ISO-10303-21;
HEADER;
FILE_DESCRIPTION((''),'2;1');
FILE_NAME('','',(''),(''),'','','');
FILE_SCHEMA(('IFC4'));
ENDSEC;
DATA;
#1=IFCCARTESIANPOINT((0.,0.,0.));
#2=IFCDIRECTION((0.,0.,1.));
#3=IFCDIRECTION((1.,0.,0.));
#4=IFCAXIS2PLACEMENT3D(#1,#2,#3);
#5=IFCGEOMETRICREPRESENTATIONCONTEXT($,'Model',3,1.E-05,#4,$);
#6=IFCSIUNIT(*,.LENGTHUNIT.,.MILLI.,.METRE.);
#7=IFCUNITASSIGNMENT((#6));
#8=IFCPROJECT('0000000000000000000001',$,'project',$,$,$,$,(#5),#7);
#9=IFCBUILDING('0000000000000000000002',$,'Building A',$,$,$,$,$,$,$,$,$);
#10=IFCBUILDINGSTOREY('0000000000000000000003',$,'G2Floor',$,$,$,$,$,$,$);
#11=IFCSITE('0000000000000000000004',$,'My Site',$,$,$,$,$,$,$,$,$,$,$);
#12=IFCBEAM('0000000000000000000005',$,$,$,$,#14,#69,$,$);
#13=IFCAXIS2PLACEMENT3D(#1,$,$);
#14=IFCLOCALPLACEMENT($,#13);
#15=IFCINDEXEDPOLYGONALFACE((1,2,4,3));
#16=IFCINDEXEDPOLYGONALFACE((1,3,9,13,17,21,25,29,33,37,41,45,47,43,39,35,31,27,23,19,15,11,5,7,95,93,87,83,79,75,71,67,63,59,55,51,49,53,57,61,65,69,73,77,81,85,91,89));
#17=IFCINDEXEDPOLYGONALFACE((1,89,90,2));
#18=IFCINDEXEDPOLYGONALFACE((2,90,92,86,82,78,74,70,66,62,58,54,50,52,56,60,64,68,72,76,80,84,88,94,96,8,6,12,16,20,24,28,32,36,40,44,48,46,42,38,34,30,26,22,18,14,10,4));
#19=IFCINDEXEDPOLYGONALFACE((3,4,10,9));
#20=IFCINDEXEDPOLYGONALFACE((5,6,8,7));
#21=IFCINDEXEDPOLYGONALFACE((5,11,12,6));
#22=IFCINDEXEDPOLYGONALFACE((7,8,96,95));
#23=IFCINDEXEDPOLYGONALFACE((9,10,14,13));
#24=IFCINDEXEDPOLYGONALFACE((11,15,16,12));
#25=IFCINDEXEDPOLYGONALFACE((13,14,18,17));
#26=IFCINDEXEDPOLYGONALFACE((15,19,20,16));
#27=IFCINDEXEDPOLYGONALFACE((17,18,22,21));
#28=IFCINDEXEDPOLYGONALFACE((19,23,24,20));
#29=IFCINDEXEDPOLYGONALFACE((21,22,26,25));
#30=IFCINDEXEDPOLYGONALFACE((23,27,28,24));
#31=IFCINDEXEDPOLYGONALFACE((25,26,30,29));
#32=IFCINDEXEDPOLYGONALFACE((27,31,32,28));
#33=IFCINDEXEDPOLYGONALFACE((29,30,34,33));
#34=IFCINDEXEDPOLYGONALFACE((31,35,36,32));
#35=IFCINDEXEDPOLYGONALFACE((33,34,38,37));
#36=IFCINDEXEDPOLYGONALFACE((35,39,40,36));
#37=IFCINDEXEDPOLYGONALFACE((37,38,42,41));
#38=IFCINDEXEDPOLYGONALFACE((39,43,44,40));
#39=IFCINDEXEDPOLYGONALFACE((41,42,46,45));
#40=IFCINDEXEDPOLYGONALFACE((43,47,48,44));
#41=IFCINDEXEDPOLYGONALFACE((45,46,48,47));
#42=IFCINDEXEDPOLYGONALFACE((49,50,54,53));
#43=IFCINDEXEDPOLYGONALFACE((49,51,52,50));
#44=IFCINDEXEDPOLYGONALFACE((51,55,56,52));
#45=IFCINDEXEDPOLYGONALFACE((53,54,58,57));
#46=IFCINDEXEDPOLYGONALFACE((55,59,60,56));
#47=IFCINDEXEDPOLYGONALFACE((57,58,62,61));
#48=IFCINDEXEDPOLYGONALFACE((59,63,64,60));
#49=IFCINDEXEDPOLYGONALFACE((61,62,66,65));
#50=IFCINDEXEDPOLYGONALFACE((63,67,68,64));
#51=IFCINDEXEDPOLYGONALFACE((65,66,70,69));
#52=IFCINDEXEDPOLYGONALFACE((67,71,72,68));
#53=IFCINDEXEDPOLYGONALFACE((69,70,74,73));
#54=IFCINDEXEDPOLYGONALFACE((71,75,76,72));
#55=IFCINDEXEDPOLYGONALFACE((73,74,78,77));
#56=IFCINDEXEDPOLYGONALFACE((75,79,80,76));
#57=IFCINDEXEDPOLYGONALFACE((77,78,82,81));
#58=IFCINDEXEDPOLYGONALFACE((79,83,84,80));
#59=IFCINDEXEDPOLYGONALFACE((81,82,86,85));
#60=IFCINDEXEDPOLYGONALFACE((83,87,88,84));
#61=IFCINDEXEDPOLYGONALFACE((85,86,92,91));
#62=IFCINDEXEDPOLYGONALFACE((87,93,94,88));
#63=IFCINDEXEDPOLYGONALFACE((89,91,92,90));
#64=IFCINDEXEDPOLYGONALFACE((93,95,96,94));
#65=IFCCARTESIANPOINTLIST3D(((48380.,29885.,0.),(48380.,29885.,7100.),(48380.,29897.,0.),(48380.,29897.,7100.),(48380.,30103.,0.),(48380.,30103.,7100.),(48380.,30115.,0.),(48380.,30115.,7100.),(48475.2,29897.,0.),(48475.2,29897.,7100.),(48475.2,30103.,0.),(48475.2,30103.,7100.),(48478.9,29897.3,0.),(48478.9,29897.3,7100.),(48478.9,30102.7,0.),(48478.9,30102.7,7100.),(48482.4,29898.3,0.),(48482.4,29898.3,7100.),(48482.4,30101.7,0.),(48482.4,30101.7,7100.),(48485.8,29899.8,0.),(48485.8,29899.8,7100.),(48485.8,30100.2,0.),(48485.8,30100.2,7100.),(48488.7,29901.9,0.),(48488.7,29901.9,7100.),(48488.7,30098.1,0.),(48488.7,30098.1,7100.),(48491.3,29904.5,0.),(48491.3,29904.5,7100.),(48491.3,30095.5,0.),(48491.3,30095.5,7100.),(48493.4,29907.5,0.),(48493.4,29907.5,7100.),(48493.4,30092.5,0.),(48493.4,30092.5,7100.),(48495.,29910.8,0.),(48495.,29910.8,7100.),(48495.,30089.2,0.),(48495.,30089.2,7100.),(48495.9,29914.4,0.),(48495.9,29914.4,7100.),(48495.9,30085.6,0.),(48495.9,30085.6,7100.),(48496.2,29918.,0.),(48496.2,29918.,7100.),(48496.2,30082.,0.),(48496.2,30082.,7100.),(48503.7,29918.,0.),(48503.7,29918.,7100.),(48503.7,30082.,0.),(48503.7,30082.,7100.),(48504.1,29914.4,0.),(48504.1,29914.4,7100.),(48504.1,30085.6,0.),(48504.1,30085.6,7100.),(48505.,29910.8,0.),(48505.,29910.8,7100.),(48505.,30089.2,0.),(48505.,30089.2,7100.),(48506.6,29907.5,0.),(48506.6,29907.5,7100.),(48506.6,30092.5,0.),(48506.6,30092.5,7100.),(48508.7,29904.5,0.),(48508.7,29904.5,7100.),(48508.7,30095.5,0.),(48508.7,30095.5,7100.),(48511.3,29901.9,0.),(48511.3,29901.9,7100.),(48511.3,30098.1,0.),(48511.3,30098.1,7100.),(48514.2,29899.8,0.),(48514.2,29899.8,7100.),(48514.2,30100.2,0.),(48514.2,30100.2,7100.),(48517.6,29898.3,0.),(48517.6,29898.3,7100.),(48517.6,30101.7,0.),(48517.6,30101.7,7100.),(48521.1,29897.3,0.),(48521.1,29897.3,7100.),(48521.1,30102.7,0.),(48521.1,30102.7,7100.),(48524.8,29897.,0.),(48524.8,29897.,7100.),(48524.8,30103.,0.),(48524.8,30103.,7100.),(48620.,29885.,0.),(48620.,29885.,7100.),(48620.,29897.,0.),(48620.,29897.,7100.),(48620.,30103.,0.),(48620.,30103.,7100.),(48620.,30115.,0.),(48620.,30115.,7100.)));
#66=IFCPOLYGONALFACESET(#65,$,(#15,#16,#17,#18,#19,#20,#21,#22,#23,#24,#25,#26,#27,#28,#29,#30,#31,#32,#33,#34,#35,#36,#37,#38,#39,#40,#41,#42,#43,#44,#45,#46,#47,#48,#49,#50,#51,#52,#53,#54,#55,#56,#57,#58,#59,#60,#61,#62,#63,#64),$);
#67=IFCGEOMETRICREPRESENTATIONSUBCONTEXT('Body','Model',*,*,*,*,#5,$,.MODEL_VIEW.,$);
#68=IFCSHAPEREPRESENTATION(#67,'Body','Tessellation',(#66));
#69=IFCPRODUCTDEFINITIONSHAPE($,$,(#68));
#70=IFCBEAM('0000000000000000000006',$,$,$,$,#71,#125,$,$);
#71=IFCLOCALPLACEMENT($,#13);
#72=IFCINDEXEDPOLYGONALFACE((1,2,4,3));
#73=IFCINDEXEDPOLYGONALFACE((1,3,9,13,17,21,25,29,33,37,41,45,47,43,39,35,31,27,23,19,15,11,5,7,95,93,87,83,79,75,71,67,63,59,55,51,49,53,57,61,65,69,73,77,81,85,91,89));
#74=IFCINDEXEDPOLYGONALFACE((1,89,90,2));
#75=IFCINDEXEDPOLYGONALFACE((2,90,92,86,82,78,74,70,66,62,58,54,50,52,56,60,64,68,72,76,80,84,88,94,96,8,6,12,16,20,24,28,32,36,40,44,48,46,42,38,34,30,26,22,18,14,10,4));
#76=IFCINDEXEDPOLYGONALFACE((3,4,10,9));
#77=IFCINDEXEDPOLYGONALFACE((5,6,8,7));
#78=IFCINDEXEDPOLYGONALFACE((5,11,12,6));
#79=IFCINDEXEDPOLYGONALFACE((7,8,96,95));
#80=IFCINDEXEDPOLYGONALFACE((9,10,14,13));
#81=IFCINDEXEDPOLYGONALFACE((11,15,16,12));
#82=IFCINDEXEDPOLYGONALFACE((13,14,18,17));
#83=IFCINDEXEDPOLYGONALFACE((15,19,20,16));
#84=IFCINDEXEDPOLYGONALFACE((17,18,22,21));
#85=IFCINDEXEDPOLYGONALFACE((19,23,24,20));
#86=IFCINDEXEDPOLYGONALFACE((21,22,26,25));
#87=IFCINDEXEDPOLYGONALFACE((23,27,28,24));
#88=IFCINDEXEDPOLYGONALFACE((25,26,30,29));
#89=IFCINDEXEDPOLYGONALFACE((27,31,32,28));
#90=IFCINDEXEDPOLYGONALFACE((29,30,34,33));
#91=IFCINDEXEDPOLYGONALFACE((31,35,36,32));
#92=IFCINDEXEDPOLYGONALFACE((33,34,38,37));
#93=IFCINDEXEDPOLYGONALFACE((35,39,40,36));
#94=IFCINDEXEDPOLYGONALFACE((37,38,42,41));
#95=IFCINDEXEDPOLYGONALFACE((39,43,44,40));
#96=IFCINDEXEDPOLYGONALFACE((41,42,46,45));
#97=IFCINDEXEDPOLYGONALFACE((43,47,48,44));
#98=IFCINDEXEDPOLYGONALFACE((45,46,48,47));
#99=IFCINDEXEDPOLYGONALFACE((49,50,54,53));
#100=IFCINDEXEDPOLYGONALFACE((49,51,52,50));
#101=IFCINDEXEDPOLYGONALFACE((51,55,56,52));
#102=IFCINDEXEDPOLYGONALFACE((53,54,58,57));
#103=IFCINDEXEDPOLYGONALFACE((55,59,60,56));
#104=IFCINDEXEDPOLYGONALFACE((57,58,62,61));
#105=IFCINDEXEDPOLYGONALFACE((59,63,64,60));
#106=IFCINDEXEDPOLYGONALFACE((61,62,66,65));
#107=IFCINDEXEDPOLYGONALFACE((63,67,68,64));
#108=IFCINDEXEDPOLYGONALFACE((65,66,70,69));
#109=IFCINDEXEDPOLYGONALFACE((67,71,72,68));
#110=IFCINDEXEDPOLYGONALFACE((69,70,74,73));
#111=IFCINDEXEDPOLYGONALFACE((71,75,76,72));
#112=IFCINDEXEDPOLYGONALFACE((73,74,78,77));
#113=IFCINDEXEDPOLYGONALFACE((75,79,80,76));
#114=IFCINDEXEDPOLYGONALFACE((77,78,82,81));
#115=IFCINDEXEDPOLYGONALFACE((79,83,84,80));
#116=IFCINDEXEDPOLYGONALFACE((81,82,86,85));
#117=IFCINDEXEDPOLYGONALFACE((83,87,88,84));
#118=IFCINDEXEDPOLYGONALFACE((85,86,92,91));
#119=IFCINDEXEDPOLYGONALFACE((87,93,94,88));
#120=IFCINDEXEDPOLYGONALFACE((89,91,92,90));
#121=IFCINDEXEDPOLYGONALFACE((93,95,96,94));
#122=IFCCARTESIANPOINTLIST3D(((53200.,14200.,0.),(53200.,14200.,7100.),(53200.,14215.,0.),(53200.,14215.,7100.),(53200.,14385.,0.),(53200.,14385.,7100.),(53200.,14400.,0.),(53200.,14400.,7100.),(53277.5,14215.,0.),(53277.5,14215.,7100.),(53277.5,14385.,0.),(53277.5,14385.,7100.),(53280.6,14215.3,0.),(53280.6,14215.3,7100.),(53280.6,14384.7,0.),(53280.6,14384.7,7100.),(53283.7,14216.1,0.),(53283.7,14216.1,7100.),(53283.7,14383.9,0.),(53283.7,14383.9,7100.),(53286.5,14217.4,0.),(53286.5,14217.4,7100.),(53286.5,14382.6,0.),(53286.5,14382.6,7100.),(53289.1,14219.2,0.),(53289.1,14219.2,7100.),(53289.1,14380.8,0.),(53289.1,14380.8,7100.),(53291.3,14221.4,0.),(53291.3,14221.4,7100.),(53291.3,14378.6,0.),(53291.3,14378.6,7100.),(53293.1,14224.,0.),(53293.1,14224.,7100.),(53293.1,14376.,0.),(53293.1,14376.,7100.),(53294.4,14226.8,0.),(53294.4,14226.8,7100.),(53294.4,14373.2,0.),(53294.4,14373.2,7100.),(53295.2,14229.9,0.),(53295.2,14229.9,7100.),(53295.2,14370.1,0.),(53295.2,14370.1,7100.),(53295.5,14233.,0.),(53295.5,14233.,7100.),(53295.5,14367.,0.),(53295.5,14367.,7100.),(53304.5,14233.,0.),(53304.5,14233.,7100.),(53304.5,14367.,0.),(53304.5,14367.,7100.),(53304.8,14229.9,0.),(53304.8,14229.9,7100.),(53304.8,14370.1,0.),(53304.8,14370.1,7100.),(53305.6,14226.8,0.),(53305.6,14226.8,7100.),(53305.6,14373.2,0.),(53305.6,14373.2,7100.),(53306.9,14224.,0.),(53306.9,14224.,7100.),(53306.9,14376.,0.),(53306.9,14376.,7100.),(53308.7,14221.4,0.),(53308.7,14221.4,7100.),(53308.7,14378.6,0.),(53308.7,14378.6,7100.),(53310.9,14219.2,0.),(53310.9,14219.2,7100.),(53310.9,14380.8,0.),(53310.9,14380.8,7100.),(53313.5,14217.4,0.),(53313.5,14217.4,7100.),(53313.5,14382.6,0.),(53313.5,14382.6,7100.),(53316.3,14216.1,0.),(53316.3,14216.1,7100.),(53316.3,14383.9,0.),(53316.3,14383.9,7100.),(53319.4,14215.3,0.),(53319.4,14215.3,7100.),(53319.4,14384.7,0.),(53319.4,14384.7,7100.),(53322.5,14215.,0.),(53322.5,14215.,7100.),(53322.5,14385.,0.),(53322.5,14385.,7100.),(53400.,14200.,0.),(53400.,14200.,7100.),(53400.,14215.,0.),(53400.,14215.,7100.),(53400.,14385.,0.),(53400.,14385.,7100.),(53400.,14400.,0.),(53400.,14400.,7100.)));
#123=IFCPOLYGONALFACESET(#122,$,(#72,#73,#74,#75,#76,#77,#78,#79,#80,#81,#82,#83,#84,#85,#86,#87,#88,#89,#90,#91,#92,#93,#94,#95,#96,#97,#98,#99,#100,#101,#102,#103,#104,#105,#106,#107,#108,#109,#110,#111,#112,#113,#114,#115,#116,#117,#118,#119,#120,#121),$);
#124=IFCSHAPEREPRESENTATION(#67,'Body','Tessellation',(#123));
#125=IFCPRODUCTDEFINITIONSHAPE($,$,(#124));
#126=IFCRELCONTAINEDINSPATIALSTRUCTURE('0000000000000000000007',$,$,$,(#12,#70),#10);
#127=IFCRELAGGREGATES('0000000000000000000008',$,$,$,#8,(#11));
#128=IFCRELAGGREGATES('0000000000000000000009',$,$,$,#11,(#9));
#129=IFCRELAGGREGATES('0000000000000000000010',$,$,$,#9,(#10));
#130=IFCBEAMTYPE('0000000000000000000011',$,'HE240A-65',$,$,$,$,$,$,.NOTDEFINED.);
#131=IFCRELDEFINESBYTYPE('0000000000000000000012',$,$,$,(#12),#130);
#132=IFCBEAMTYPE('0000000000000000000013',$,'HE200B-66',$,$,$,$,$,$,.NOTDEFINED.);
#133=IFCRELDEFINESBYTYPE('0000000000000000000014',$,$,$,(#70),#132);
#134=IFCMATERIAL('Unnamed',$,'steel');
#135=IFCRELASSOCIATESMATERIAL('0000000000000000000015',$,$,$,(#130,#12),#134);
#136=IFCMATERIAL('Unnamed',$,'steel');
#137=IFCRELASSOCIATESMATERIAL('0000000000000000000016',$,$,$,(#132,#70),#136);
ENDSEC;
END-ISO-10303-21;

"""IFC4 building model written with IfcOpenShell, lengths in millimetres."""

from ifc_helpers import new_model, si_unit, frame, origin_with_axes, place, context, subcontext, project, spatial, polyline, outline, extrude, material, material_profile, profile_set, profile_usage, type_object, element, save


model = new_model("IFC4")

# Units and contexts
model_context = context("Model", 3, precision=1e-05, world=origin_with_axes())
body_context = subcontext(model_context, "Body", "Model", "MODEL_VIEW")
ifc_project = project(units=[si_unit("LENGTHUNIT", "METRE", prefix="MILLI")], contexts=[model_context])

# Site, building, storey
site = spatial("IfcSite", under=ifc_project, Name="My Site")
building = spatial("IfcBuilding", under=site, Name="Building A")
storey = spatial("IfcBuildingStorey", under=building, Name="G2Floor")

# Beams
ifc_material_1 = material(Name="Unnamed", Category="steel")
ifc_material_profile_1 = material_profile(ifc_material_1, outline(polyline([(120.0, -115.0), (120.0, -103.0), (120.0, -103.0), (24.8, -103.0), (24.8, -103.0), (21.1, -102.7), (21.1, -102.7), (17.6, -101.7), (17.6, -101.7), (14.2, -100.2), (14.2, -100.2), (11.3, -98.1), (11.3, -98.1), (8.7, -95.5), (8.7, -95.5), (6.6, -92.5), (6.6, -92.5), (5.0, -89.2), (5.0, -89.2), (4.1, -85.6), (4.1, -85.6), (3.8, -82.0), (3.8, -82.0), (3.8, 82.0), (3.8, 82.0), (4.1, 85.6), (4.1, 85.6), (5.0, 89.2), (5.0, 89.2), (6.6, 92.5), (6.6, 92.5), (8.7, 95.5), (8.7, 95.5), (11.3, 98.1), (11.3, 98.1), (14.2, 100.2), (14.2, 100.2), (17.6, 101.7), (17.6, 101.7), (21.1, 102.7), (21.1, 102.7), (24.8, 103.0), (24.8, 103.0), (120.0, 103.0), (120.0, 103.0), (120.0, 115.0), (120.0, 115.0), (-120.0, 115.0), (-120.0, 115.0), (-120.0, 103.0), (-120.0, 103.0), (-24.8, 103.0), (-24.8, 103.0), (-21.1, 102.7), (-21.1, 102.7), (-17.6, 101.7), (-17.6, 101.7), (-14.2, 100.2), (-14.2, 100.2), (-11.3, 98.1), (-11.3, 98.1), (-8.7, 95.5), (-8.7, 95.5), (-6.6, 92.5), (-6.6, 92.5), (-5.0, 89.2), (-5.0, 89.2), (-4.1, 85.6), (-4.1, 85.6), (-3.8, 82.0), (-3.8, 82.0), (-3.8, -82.0), (-3.8, -82.0), (-4.1, -85.6), (-4.1, -85.6), (-5.0, -89.2), (-5.0, -89.2), (-6.6, -92.5), (-6.6, -92.5), (-8.7, -95.5), (-8.7, -95.5), (-11.3, -98.1), (-11.3, -98.1), (-14.2, -100.2), (-14.2, -100.2), (-17.6, -101.7), (-17.6, -101.7), (-21.1, -102.7), (-21.1, -102.7), (-24.8, -103.0), (-24.8, -103.0), (-120.0, -103.0), (-120.0, -103.0), (-120.0, -115.0), (-120.0, -115.0), (120.0, -115.0)])))
ifc_profile_set_1 = profile_set([ifc_material_profile_1], Name="HE240A-65")
ifc_profile_usage_1 = profile_usage(ifc_profile_set_1)
beam_type_1 = type_object("IfcBeamType", Name="HE240A-65", PredefinedType="NOTDEFINED", material=ifc_profile_set_1)
beam_1_placement = place(None, frame((48500.0, 30000.0, 0.0), z_axis=(0.0, 0.0, 1.0), x_axis=(1.0, 0.0, 0.0)))
element("IfcBeam", 1, at=beam_1_placement, inside=storey, type_object=beam_type_1, material=ifc_profile_usage_1, context=body_context, shape_type="SweptSolid", body=[
    extrude(outline(polyline([(120.0, -115.0), (120.0, -103.0), (120.0, -103.0), (24.8, -103.0), (24.8, -103.0), (21.1, -102.7), (21.1, -102.7), (17.6, -101.7), (17.6, -101.7), (14.2, -100.2), (14.2, -100.2), (11.3, -98.1), (11.3, -98.1), (8.7, -95.5), (8.7, -95.5), (6.6, -92.5), (6.6, -92.5), (5.0, -89.2), (5.0, -89.2), (4.1, -85.6), (4.1, -85.6), (3.8, -82.0), (3.8, -82.0), (3.8, 82.0), (3.8, 82.0), (4.1, 85.6), (4.1, 85.6), (5.0, 89.2), (5.0, 89.2), (6.6, 92.5), (6.6, 92.5), (8.7, 95.5), (8.7, 95.5), (11.3, 98.1), (11.3, 98.1), (14.2, 100.2), (14.2, 100.2), (17.6, 101.7), (17.6, 101.7), (21.1, 102.7), (21.1, 102.7), (24.8, 103.0), (24.8, 103.0), (120.0, 103.0), (120.0, 103.0), (120.0, 115.0), (120.0, 115.0), (-120.0, 115.0), (-120.0, 115.0), (-120.0, 103.0), (-120.0, 103.0), (-24.8, 103.0), (-24.8, 103.0), (-21.1, 102.7), (-21.1, 102.7), (-17.6, 101.7), (-17.6, 101.7), (-14.2, 100.2), (-14.2, 100.2), (-11.3, 98.1), (-11.3, 98.1), (-8.7, 95.5), (-8.7, 95.5), (-6.6, 92.5), (-6.6, 92.5), (-5.0, 89.2), (-5.0, 89.2), (-4.1, 85.6), (-4.1, 85.6), (-3.8, 82.0), (-3.8, 82.0), (-3.8, -82.0), (-3.8, -82.0), (-4.1, -85.6), (-4.1, -85.6), (-5.0, -89.2), (-5.0, -89.2), (-6.6, -92.5), (-6.6, -92.5), (-8.7, -95.5), (-8.7, -95.5), (-11.3, -98.1), (-11.3, -98.1), (-14.2, -100.2), (-14.2, -100.2), (-17.6, -101.7), (-17.6, -101.7), (-21.1, -102.7), (-21.1, -102.7), (-24.8, -103.0), (-24.8, -103.0), (-120.0, -103.0), (-120.0, -103.0), (-120.0, -115.0), (-120.0, -115.0), (120.0, -115.0)])), origin_with_axes(), (0.0, 0.0, 1.0), 7100.0),
])
ifc_material_2 = material(Name="Unnamed", Category="steel")
ifc_material_profile_2 = material_profile(ifc_material_2, outline(polyline([(100.0, -100.0), (100.0, -85.0), (100.0, -85.0), (22.5, -85.0), (22.5, -85.0), (19.4, -84.7), (19.4, -84.7), (16.3, -83.9), (16.3, -83.9), (13.5, -82.6), (13.5, -82.6), (10.9, -80.8), (10.9, -80.8), (8.7, -78.6), (8.7, -78.6), (6.9, -76.0), (6.9, -76.0), (5.6, -73.2), (5.6, -73.2), (4.8, -70.1), (4.8, -70.1), (4.5, -67.0), (4.5, -67.0), (4.5, 67.0), (4.5, 67.0), (4.8, 70.1), (4.8, 70.1), (5.6, 73.2), (5.6, 73.2), (6.9, 76.0), (6.9, 76.0), (8.7, 78.6), (8.7, 78.6), (10.9, 80.8), (10.9, 80.8), (13.5, 82.6), (13.5, 82.6), (16.3, 83.9), (16.3, 83.9), (19.4, 84.7), (19.4, 84.7), (22.5, 85.0), (22.5, 85.0), (100.0, 85.0), (100.0, 85.0), (100.0, 100.0), (100.0, 100.0), (-100.0, 100.0), (-100.0, 100.0), (-100.0, 85.0), (-100.0, 85.0), (-22.5, 85.0), (-22.5, 85.0), (-19.4, 84.7), (-19.4, 84.7), (-16.3, 83.9), (-16.3, 83.9), (-13.5, 82.6), (-13.5, 82.6), (-10.9, 80.8), (-10.9, 80.8), (-8.7, 78.6), (-8.7, 78.6), (-6.9, 76.0), (-6.9, 76.0), (-5.6, 73.2), (-5.6, 73.2), (-4.8, 70.1), (-4.8, 70.1), (-4.5, 67.0), (-4.5, 67.0), (-4.5, -67.0), (-4.5, -67.0), (-4.8, -70.1), (-4.8, -70.1), (-5.6, -73.2), (-5.6, -73.2), (-6.9, -76.0), (-6.9, -76.0), (-8.7, -78.6), (-8.7, -78.6), (-10.9, -80.8), (-10.9, -80.8), (-13.5, -82.6), (-13.5, -82.6), (-16.3, -83.9), (-16.3, -83.9), (-19.4, -84.7), (-19.4, -84.7), (-22.5, -85.0), (-22.5, -85.0), (-100.0, -85.0), (-100.0, -85.0), (-100.0, -100.0), (-100.0, -100.0), (100.0, -100.0)])))
ifc_profile_set_2 = profile_set([ifc_material_profile_2], Name="HE200B-66")
ifc_profile_usage_2 = profile_usage(ifc_profile_set_2)
beam_type_2 = type_object("IfcBeamType", Name="HE200B-66", PredefinedType="NOTDEFINED", material=ifc_profile_set_2)
beam_2_placement = place(None, frame((53300.0, 14300.0, 0.0), z_axis=(0.0, 0.0, 1.0), x_axis=(1.0, 0.0, 0.0)))
element("IfcBeam", 2, at=beam_2_placement, inside=storey, type_object=beam_type_2, material=ifc_profile_usage_2, context=body_context, shape_type="SweptSolid", body=[
    extrude(outline(polyline([(100.0, -100.0), (100.0, -85.0), (100.0, -85.0), (22.5, -85.0), (22.5, -85.0), (19.4, -84.7), (19.4, -84.7), (16.3, -83.9), (16.3, -83.9), (13.5, -82.6), (13.5, -82.6), (10.9, -80.8), (10.9, -80.8), (8.7, -78.6), (8.7, -78.6), (6.9, -76.0), (6.9, -76.0), (5.6, -73.2), (5.6, -73.2), (4.8, -70.1), (4.8, -70.1), (4.5, -67.0), (4.5, -67.0), (4.5, 67.0), (4.5, 67.0), (4.8, 70.1), (4.8, 70.1), (5.6, 73.2), (5.6, 73.2), (6.9, 76.0), (6.9, 76.0), (8.7, 78.6), (8.7, 78.6), (10.9, 80.8), (10.9, 80.8), (13.5, 82.6), (13.5, 82.6), (16.3, 83.9), (16.3, 83.9), (19.4, 84.7), (19.4, 84.7), (22.5, 85.0), (22.5, 85.0), (100.0, 85.0), (100.0, 85.0), (100.0, 100.0), (100.0, 100.0), (-100.0, 100.0), (-100.0, 100.0), (-100.0, 85.0), (-100.0, 85.0), (-22.5, 85.0), (-22.5, 85.0), (-19.4, 84.7), (-19.4, 84.7), (-16.3, 83.9), (-16.3, 83.9), (-13.5, 82.6), (-13.5, 82.6), (-10.9, 80.8), (-10.9, 80.8), (-8.7, 78.6), (-8.7, 78.6), (-6.9, 76.0), (-6.9, 76.0), (-5.6, 73.2), (-5.6, 73.2), (-4.8, 70.1), (-4.8, 70.1), (-4.5, 67.0), (-4.5, 67.0), (-4.5, -67.0), (-4.5, -67.0), (-4.8, -70.1), (-4.8, -70.1), (-5.6, -73.2), (-5.6, -73.2), (-6.9, -76.0), (-6.9, -76.0), (-8.7, -78.6), (-8.7, -78.6), (-10.9, -80.8), (-10.9, -80.8), (-13.5, -82.6), (-13.5, -82.6), (-16.3, -83.9), (-16.3, -83.9), (-19.4, -84.7), (-19.4, -84.7), (-22.5, -85.0), (-22.5, -85.0), (-100.0, -85.0), (-100.0, -85.0), (-100.0, -100.0), (-100.0, -100.0), (100.0, -100.0)])), origin_with_axes(), (0.0, 0.0, 1.0), 7100.0),
])

save(model, "model.ifc")
